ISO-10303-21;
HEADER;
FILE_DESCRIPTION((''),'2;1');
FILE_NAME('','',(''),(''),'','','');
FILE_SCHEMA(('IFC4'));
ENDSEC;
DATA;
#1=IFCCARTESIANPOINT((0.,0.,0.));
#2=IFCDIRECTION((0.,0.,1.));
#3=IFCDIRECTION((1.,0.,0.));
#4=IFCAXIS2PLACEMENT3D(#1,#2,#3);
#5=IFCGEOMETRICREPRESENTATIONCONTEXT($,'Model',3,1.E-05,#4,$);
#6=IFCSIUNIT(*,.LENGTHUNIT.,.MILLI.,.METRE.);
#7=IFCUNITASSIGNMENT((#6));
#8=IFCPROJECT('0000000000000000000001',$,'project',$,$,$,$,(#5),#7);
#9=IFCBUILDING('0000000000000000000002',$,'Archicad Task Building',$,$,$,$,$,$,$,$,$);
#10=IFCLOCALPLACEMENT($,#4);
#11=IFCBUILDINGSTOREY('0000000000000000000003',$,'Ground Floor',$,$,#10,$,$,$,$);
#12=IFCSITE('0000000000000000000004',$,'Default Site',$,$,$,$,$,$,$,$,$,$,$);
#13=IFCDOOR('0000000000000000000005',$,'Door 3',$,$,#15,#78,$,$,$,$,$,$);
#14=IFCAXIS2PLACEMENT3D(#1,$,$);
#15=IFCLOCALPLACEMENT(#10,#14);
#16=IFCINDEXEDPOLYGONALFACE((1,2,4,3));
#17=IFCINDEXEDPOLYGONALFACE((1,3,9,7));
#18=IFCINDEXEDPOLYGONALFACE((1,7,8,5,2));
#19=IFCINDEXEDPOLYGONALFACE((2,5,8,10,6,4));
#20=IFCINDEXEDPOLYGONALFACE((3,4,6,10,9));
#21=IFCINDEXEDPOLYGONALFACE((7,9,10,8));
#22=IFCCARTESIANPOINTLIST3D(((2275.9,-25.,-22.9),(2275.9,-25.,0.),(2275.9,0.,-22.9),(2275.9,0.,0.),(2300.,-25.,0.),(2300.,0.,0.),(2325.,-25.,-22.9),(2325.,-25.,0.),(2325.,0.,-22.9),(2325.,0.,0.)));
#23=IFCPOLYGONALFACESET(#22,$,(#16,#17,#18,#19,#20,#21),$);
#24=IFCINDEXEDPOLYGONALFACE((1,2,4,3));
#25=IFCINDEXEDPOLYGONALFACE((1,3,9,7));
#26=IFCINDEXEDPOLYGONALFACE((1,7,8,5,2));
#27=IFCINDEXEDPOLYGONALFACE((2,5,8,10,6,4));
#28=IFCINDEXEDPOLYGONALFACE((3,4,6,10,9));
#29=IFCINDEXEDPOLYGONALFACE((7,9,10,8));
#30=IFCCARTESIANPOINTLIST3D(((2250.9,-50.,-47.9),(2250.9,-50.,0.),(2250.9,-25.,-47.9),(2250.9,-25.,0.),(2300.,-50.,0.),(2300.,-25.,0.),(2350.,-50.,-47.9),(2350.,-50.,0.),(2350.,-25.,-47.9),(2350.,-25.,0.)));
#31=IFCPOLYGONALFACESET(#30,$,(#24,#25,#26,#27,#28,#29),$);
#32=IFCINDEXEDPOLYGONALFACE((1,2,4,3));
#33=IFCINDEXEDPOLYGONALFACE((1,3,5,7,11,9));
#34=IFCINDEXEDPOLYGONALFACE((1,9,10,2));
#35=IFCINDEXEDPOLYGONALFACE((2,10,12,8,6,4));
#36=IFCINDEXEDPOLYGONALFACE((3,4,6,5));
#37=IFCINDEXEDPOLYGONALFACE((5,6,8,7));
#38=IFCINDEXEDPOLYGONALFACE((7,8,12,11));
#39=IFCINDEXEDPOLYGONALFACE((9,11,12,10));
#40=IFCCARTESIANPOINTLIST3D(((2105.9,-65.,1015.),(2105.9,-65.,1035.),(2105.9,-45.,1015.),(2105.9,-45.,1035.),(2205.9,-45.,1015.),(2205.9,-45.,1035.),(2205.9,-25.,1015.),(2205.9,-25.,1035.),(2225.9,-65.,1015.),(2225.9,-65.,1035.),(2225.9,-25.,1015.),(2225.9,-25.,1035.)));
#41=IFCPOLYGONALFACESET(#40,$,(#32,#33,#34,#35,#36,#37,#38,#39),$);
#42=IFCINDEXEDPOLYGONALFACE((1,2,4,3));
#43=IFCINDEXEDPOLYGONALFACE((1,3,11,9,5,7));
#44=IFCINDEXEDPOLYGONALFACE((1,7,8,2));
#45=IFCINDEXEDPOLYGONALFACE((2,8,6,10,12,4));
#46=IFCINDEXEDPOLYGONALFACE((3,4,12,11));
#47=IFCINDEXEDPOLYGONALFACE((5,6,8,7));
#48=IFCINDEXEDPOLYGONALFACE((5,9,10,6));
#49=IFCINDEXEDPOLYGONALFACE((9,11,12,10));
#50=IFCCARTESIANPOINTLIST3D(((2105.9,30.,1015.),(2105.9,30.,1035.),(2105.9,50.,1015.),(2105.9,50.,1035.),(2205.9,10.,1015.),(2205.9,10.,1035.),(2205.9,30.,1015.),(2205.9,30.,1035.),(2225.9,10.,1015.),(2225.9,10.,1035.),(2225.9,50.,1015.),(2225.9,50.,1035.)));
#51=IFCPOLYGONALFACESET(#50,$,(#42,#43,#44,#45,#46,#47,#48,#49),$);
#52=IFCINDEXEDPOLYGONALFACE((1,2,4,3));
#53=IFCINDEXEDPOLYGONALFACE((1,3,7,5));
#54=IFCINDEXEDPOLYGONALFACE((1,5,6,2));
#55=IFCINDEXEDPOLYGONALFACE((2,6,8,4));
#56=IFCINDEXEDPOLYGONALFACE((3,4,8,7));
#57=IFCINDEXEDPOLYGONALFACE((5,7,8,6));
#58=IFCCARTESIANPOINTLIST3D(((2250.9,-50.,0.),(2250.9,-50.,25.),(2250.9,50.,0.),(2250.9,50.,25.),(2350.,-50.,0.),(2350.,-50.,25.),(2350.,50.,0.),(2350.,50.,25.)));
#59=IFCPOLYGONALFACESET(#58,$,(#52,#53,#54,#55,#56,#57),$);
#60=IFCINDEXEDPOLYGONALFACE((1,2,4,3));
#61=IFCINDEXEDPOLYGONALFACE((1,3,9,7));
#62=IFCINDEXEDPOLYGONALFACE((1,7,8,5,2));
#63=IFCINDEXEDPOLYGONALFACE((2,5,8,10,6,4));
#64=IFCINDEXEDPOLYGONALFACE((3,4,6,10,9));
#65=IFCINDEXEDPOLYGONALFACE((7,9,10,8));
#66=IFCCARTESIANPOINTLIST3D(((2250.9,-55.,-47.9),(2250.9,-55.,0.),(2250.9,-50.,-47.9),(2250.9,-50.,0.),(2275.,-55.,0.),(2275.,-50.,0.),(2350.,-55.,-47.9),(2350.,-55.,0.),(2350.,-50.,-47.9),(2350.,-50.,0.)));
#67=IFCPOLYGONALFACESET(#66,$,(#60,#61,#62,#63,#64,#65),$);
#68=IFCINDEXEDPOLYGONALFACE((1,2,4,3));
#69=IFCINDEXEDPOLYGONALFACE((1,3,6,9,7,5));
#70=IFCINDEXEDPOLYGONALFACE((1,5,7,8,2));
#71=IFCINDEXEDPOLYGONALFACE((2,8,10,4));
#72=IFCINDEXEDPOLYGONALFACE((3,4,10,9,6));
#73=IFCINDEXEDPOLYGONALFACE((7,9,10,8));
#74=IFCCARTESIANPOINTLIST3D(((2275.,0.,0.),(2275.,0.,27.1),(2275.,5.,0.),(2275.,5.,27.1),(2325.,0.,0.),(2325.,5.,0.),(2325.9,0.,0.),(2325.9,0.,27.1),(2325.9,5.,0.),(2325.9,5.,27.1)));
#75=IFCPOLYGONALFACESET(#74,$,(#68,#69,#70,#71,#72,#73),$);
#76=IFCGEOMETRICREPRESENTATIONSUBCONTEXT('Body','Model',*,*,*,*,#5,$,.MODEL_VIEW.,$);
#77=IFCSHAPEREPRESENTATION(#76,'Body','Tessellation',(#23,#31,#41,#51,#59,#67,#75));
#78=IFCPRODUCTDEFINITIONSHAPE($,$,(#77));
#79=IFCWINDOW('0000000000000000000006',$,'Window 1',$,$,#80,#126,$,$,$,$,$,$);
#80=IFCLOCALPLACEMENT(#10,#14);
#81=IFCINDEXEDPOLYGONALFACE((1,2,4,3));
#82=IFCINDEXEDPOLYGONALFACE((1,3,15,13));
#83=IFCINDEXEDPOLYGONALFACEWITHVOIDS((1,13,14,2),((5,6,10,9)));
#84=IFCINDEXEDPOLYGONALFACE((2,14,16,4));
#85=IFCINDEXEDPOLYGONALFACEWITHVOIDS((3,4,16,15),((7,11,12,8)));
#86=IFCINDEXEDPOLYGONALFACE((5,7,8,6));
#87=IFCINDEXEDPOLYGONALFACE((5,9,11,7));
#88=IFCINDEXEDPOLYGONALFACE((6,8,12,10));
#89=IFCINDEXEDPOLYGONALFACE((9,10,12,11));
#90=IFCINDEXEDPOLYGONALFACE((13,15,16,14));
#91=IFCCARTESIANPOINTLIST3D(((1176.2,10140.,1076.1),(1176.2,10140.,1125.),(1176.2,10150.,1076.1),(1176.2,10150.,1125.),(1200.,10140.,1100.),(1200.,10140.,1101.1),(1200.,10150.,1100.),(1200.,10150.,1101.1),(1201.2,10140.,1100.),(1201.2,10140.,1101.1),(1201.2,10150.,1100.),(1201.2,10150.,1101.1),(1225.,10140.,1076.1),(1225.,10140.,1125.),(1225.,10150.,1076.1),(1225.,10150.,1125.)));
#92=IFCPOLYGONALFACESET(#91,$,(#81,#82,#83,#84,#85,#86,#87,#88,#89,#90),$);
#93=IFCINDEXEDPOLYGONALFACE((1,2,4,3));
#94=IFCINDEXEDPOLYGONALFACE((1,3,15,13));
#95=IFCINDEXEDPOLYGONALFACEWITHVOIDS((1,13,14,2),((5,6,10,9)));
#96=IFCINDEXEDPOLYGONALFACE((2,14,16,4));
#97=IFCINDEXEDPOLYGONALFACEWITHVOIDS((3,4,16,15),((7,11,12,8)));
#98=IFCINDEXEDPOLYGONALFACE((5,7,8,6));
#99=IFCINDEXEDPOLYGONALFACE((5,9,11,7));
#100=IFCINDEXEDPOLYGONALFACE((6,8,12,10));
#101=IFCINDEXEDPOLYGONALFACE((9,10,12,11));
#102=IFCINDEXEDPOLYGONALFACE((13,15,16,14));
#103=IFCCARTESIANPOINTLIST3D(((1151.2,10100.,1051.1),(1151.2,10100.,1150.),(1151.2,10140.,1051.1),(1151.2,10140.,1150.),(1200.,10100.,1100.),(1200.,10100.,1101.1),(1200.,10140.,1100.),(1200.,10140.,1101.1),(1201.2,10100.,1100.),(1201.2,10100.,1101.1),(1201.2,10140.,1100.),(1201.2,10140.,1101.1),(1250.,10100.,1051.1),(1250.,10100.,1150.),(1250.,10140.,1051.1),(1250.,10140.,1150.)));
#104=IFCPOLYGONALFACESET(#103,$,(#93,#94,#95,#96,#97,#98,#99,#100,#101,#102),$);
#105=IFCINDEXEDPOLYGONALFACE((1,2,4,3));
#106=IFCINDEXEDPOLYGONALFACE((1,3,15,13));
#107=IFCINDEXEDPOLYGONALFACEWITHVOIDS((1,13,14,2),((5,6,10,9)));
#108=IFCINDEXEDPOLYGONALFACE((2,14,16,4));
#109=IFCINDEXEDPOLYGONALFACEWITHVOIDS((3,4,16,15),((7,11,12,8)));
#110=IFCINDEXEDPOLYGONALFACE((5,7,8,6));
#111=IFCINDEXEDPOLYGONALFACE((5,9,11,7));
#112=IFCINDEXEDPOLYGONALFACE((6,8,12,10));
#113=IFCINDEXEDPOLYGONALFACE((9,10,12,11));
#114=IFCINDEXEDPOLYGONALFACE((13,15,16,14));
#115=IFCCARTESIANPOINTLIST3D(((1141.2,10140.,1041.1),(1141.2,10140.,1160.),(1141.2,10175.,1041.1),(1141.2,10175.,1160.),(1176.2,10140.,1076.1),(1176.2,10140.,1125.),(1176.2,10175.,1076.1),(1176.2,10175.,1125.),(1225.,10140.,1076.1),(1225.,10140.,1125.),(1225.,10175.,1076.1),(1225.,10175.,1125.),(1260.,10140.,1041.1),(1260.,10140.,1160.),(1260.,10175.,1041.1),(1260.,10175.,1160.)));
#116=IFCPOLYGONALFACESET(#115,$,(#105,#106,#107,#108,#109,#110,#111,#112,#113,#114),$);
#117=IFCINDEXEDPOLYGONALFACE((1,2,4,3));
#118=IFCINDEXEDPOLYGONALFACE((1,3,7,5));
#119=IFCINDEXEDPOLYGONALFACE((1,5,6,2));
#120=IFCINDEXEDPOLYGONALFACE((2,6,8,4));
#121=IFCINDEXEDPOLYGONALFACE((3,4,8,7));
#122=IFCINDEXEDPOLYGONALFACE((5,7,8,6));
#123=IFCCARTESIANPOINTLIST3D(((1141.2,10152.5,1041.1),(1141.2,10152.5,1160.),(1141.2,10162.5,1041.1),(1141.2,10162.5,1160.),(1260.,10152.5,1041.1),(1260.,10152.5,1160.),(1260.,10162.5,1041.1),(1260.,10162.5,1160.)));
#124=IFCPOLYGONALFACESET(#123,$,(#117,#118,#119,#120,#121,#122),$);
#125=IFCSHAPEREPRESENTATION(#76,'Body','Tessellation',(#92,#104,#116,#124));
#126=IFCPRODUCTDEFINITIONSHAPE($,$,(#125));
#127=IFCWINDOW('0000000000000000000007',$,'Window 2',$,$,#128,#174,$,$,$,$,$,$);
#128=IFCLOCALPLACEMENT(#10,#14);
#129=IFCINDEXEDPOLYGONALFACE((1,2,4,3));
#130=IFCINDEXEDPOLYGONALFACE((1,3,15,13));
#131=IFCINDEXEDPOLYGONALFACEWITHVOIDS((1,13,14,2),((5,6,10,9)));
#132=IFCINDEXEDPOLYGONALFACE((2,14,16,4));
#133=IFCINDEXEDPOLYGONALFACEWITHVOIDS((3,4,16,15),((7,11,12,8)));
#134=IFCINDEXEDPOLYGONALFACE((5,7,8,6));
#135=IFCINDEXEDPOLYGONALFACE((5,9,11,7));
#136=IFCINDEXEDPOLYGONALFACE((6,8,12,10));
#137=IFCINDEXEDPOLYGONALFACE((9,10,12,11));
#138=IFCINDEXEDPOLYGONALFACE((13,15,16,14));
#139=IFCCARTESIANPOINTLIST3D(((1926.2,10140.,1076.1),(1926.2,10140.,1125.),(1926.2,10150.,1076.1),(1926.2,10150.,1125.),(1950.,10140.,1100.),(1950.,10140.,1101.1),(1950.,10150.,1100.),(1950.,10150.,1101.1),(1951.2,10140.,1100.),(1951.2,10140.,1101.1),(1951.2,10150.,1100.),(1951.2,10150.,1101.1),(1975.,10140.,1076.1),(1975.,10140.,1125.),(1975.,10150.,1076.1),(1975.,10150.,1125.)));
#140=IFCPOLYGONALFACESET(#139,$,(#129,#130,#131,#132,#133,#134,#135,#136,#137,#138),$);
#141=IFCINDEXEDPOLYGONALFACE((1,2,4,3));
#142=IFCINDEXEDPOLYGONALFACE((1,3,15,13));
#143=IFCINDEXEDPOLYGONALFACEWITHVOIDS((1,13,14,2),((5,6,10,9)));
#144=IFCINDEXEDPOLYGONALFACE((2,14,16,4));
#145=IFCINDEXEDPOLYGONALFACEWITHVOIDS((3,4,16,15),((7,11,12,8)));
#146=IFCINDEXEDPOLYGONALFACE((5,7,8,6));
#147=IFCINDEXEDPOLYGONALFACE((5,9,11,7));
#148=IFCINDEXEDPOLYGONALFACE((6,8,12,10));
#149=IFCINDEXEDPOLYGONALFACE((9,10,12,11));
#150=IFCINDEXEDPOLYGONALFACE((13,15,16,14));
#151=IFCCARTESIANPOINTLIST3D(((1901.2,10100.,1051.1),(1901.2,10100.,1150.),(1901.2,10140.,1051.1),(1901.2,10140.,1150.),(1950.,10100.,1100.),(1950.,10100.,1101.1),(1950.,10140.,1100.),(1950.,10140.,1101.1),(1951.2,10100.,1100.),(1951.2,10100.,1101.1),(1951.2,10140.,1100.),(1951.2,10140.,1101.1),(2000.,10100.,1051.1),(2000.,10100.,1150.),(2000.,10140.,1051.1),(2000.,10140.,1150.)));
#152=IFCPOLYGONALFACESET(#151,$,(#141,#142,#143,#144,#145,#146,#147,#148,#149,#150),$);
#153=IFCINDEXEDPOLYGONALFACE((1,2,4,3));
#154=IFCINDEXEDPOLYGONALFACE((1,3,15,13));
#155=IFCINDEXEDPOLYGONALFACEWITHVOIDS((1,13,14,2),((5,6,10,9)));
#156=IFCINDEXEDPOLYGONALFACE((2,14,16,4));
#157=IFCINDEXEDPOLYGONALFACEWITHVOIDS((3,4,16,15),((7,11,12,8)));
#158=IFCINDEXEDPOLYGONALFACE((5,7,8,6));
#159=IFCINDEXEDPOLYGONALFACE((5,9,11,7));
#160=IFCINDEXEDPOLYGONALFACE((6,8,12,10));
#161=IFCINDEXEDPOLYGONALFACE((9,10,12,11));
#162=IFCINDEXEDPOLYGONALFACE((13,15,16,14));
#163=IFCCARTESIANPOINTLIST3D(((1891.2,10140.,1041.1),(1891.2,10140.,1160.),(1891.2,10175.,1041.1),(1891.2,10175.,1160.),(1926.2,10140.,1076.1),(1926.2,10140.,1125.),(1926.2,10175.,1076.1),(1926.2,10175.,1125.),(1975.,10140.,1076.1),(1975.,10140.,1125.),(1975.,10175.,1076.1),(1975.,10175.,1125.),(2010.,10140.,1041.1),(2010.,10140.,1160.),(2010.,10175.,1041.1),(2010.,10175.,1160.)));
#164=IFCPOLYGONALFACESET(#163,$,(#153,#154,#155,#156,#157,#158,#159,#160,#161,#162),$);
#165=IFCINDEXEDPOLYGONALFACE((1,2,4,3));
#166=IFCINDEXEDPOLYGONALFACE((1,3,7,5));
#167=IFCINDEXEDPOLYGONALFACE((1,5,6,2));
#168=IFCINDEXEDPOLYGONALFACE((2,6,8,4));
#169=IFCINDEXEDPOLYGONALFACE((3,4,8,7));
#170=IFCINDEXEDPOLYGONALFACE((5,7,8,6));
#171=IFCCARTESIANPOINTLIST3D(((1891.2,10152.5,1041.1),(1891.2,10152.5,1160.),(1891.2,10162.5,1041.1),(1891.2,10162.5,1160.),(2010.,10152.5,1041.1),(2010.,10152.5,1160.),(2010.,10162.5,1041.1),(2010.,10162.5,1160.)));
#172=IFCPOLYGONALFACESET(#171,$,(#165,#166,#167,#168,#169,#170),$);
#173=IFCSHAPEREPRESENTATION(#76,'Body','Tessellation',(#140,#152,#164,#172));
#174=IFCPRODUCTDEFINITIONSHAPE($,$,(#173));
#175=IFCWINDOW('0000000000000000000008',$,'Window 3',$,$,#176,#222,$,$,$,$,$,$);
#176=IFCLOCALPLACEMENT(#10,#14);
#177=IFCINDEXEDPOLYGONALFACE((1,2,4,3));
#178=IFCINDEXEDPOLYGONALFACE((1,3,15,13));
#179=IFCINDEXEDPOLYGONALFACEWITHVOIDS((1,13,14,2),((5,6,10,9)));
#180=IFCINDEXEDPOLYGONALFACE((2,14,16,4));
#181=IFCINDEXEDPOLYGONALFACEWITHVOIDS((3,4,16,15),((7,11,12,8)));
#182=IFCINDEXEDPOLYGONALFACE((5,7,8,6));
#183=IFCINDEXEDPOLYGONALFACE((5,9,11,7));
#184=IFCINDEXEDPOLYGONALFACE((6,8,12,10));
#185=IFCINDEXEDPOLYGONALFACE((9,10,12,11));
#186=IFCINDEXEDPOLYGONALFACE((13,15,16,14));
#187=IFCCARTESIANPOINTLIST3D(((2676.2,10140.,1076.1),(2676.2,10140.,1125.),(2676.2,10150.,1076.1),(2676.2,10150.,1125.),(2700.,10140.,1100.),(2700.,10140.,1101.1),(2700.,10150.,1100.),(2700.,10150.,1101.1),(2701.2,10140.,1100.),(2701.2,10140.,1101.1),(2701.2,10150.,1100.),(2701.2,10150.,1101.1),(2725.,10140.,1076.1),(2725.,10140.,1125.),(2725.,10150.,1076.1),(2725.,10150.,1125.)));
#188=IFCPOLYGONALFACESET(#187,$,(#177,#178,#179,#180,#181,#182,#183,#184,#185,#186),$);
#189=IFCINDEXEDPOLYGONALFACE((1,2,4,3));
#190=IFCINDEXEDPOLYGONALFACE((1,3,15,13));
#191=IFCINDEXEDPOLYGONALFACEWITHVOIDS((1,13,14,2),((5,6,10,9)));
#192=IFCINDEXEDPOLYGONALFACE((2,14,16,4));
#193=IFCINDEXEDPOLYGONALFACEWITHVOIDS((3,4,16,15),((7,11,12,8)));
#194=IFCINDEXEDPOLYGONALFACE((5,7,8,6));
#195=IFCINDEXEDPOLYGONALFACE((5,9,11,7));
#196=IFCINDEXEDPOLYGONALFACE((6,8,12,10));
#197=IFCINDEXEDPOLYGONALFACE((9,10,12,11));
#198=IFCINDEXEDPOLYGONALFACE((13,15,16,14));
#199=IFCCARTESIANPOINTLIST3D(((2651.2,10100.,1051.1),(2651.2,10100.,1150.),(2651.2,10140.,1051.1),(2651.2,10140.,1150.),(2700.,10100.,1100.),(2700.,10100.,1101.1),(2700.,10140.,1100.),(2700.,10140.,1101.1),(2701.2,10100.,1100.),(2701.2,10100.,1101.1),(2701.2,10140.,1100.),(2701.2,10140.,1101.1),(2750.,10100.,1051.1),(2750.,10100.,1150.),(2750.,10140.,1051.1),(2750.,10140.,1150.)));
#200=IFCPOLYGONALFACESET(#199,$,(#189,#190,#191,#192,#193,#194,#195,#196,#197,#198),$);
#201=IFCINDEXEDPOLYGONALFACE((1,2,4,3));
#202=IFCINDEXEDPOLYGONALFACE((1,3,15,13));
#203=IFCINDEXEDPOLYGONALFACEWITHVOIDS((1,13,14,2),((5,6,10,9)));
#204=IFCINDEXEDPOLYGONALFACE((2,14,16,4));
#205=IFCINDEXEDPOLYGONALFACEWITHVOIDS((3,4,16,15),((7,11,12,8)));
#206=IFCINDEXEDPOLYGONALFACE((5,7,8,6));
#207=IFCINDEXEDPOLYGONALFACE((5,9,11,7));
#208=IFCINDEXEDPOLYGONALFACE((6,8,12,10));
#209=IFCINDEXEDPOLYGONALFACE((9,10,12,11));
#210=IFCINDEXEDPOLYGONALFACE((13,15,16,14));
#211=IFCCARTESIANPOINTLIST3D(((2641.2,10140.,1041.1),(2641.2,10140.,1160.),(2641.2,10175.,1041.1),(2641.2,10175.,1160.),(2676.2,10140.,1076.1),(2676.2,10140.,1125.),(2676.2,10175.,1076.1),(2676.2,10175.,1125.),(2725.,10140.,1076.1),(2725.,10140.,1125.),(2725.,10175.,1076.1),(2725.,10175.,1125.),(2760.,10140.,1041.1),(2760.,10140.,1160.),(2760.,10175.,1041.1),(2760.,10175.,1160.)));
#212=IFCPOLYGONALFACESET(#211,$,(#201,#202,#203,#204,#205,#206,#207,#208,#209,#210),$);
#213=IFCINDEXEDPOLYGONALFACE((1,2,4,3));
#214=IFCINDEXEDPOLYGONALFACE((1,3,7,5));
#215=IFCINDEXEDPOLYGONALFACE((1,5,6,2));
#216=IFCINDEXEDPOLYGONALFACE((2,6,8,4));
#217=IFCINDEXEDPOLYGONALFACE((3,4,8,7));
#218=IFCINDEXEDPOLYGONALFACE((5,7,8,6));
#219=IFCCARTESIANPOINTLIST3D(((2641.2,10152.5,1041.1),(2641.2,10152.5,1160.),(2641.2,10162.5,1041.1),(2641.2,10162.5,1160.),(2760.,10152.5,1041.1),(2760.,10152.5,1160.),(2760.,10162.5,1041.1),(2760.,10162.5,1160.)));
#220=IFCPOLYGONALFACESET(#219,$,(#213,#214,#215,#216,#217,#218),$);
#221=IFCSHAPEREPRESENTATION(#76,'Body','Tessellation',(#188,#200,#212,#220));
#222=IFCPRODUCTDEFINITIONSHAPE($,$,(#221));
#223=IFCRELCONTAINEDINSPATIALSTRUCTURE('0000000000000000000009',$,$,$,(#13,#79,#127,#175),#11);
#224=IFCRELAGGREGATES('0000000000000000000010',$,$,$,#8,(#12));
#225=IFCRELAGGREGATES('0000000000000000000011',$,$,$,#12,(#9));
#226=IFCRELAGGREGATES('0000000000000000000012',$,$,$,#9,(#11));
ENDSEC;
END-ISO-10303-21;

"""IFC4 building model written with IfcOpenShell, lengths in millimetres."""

from ifc_helpers import new_model, si_unit, frame, origin_with_axes, place, context, subcontext, project, spatial, line, indexed_curve, outline, extrude, element, save


model = new_model("IFC4")

# Units and contexts
model_context = context("Model", 3, precision=1e-05, world=origin_with_axes())
body_context = subcontext(model_context, "Body", "Model", "MODEL_VIEW")
ifc_project = project(units=[si_unit("LENGTHUNIT", "METRE", prefix="MILLI")], contexts=[model_context])

# Site, building, storey
site = spatial("IfcSite", under=ifc_project, Name="Default Site")
building = spatial("IfcBuilding", under=site, Name="Archicad Task Building")
storey_placement = place(None, origin_with_axes())
storey = spatial("IfcBuildingStorey", under=building, at=storey_placement, Name="Ground Floor")

# Door
door_1_placement = place(storey_placement, frame((2300.0, -50.0, 0.0), z_axis=(0.0, 0.0, 1.0), x_axis=(1.0, 0.0, 0.0)))
element("IfcDoor", 1, at=door_1_placement, inside=storey, Name="Door 3", context=body_context, shape_type="SweptSolid", body=[
    extrude(outline(indexed_curve([(0.0, 0.0), (0.0, 2.1), (0.9, 2.1), (0.9, 0.0), (-24.1, 0.0), (-24.1, -22.9), (25.0, -22.9), (25.0, 0.0)], segments=[line(1, 2, 3, 4, 5, 6, 7, 8, 1)])), frame((0.0, 25.0, 0.0), z_axis=(0.0, -1.0, 0.0), x_axis=(1.0, 0.0, 0.0)), (0.0, 0.0, -1.0), 25.0),
    extrude(outline(indexed_curve([(0.0, 0.0), (0.0, 2.1), (0.9, 2.1), (0.9, 0.0), (-49.1, 0.0), (-49.1, -47.9), (50.0, -47.9), (50.0, 0.0)], segments=[line(1, 2, 3, 4, 5, 6, 7, 8, 1)])), frame((0.0, 0.0, 0.0), z_axis=(0.0, -1.0, 0.0), x_axis=(1.0, 0.0, 0.0)), (0.0, 0.0, -1.0), 25.0),
    extrude(outline(indexed_curve([(0.0, 0.0), (-49.1, 0.0), (-49.1, 35.0), (0.0, 35.0)], segments=[line(1, 2, 3, 4, 1)])), frame((25.0, 25.0, 25.0), z_axis=(0.0, 0.0, 1.0), x_axis=(1.0, 0.0, 0.0)), (0.0, 0.0, 1.0), -47.9),
    extrude(outline(indexed_curve([(0.0, 0.0), (0.0, -40.0), (-120.0, -40.0), (-120.0, -20.0), (-20.0, -20.0), (-20.0, 0.0)], segments=[line(1, 2, 3, 4, 5, 6, 1)])), frame((-74.1, 25.0, 1015.0), z_axis=(0.0, 0.0, 1.0), x_axis=(1.0, 0.0, 0.0)), (0.0, 0.0, 1.0), 20.0),
    extrude(outline(indexed_curve([(0.0, 0.0), (0.0, 40.0), (-120.0, 40.0), (-120.0, 20.0), (-20.0, 20.0), (-20.0, 0.0)], segments=[line(1, 2, 3, 4, 5, 6, 1)])), frame((-74.1, 60.0, 1015.0), z_axis=(0.0, 0.0, 1.0), x_axis=(1.0, 0.0, 0.0)), (0.0, 0.0, 1.0), 20.0),
    extrude(outline(indexed_curve([(0.0, 0.0), (-99.1, 0.0), (-99.1, 100.0), (0.0, 100.0)], segments=[line(1, 2, 3, 4, 1)])), frame((50.0, 0.0, 0.0), z_axis=(0.0, 0.0, 1.0), x_axis=(1.0, 0.0, 0.0)), (0.0, 0.0, 1.0), 25.0),
    extrude(outline(indexed_curve([(0.0, 0.0), (0.0, 27.1), (50.9, 27.1), (50.9, 0.0), (-24.1, 0.0), (-24.1, -47.9), (75.0, -47.9), (75.0, 0.0)], segments=[line(1, 2, 3, 4, 5, 6, 7, 8, 1)])), frame((-25.0, -5.0, 0.0), z_axis=(0.0, -1.0, 0.0), x_axis=(1.0, 0.0, 0.0)), (0.0, 0.0, -1.0), 5.0),
    extrude(outline(indexed_curve([(0.0, 0.0), (0.0, 27.1), (50.9, 27.1), (50.9, 0.0), (0.9, 0.0), (0.9, -22.9), (50.0, -22.9), (50.0, 0.0)], segments=[line(1, 2, 3, 4, 5, 6, 7, 8, 1)])), frame((-25.0, 50.0, 0.0), z_axis=(0.0, -1.0, 0.0), x_axis=(1.0, 0.0, 0.0)), (0.0, 0.0, -1.0), 5.0),
])

# Windows
for number, where, z_axis, x_axis, name in (
    (2, (1200.0, 10050.0, 1100.0), (0.0, 0.0, 1.0), (1.0, 0.0, 0.0), "Window 1"),
    (3, (1950.0, 10050.0, 1100.0), (0.0, 0.0, 1.0), (1.0, 0.0, 0.0), "Window 2"),
    (4, (2700.0, 10050.0, 1100.0), (0.0, 0.0, 1.0), (1.0, 0.0, 0.0), "Window 3"),
):
    element("IfcWindow", number, at=place(storey_placement, frame(where, z_axis=z_axis, x_axis=x_axis)), inside=storey, Name=name, context=body_context, shape_type="SweptSolid", body=[
        extrude(outline(indexed_curve([(0.0, 0.0), (1.2, 0.0), (1.2, 1.1), (0.0, 1.1)], segments=[line(1, 2, 3, 4, 1)]), holes=[indexed_curve([(25.0, 25.0), (-23.8, 25.0), (-23.8, -23.9), (25.0, -23.9)], segments=[line(1, 2, 3, 4, 1)])]), frame((0.0, 90.0, 0.0), z_axis=(0.0, -1.0, 0.0), x_axis=(1.0, 0.0, 0.0)), (0.0, 0.0, -1.0), 10.0),
        extrude(outline(indexed_curve([(0.0, 0.0), (1.2, 0.0), (1.2, 1.1), (0.0, 1.1)], segments=[line(1, 2, 3, 4, 1)]), holes=[indexed_curve([(50.0, 50.0), (-48.8, 50.0), (-48.8, -48.9), (50.0, -48.9)], segments=[line(1, 2, 3, 4, 1)])]), frame((0.0, 50.0, 0.0), z_axis=(0.0, -1.0, 0.0), x_axis=(1.0, 0.0, 0.0)), (0.0, 0.0, -1.0), 40.0),
        extrude(outline(indexed_curve([(0.0, 0.0), (-48.8, 0.0), (-48.8, -48.9), (0.0, -48.9)], segments=[line(1, 2, 3, 4, 1)]), holes=[indexed_curve([(35.0, 35.0), (-83.8, 35.0), (-83.8, -83.9), (35.0, -83.9)], segments=[line(1, 2, 3, 4, 1)])]), frame((25.0, 90.0, 25.0), z_axis=(0.0, -1.0, 0.0), x_axis=(1.0, 0.0, 0.0)), (0.0, 0.0, -1.0), 35.0),
        extrude(outline(indexed_curve([(35.0, 35.0), (-83.8, 35.0), (-83.8, -83.9), (35.0, -83.9)], segments=[line(1, 2, 3, 4, 1)])), frame((25.0, 102.5, 25.0), z_axis=(0.0, -1.0, 0.0), x_axis=(1.0, 0.0, 0.0)), (0.0, 0.0, -1.0), 10.0),
    ])

save(model, "model.ifc")
